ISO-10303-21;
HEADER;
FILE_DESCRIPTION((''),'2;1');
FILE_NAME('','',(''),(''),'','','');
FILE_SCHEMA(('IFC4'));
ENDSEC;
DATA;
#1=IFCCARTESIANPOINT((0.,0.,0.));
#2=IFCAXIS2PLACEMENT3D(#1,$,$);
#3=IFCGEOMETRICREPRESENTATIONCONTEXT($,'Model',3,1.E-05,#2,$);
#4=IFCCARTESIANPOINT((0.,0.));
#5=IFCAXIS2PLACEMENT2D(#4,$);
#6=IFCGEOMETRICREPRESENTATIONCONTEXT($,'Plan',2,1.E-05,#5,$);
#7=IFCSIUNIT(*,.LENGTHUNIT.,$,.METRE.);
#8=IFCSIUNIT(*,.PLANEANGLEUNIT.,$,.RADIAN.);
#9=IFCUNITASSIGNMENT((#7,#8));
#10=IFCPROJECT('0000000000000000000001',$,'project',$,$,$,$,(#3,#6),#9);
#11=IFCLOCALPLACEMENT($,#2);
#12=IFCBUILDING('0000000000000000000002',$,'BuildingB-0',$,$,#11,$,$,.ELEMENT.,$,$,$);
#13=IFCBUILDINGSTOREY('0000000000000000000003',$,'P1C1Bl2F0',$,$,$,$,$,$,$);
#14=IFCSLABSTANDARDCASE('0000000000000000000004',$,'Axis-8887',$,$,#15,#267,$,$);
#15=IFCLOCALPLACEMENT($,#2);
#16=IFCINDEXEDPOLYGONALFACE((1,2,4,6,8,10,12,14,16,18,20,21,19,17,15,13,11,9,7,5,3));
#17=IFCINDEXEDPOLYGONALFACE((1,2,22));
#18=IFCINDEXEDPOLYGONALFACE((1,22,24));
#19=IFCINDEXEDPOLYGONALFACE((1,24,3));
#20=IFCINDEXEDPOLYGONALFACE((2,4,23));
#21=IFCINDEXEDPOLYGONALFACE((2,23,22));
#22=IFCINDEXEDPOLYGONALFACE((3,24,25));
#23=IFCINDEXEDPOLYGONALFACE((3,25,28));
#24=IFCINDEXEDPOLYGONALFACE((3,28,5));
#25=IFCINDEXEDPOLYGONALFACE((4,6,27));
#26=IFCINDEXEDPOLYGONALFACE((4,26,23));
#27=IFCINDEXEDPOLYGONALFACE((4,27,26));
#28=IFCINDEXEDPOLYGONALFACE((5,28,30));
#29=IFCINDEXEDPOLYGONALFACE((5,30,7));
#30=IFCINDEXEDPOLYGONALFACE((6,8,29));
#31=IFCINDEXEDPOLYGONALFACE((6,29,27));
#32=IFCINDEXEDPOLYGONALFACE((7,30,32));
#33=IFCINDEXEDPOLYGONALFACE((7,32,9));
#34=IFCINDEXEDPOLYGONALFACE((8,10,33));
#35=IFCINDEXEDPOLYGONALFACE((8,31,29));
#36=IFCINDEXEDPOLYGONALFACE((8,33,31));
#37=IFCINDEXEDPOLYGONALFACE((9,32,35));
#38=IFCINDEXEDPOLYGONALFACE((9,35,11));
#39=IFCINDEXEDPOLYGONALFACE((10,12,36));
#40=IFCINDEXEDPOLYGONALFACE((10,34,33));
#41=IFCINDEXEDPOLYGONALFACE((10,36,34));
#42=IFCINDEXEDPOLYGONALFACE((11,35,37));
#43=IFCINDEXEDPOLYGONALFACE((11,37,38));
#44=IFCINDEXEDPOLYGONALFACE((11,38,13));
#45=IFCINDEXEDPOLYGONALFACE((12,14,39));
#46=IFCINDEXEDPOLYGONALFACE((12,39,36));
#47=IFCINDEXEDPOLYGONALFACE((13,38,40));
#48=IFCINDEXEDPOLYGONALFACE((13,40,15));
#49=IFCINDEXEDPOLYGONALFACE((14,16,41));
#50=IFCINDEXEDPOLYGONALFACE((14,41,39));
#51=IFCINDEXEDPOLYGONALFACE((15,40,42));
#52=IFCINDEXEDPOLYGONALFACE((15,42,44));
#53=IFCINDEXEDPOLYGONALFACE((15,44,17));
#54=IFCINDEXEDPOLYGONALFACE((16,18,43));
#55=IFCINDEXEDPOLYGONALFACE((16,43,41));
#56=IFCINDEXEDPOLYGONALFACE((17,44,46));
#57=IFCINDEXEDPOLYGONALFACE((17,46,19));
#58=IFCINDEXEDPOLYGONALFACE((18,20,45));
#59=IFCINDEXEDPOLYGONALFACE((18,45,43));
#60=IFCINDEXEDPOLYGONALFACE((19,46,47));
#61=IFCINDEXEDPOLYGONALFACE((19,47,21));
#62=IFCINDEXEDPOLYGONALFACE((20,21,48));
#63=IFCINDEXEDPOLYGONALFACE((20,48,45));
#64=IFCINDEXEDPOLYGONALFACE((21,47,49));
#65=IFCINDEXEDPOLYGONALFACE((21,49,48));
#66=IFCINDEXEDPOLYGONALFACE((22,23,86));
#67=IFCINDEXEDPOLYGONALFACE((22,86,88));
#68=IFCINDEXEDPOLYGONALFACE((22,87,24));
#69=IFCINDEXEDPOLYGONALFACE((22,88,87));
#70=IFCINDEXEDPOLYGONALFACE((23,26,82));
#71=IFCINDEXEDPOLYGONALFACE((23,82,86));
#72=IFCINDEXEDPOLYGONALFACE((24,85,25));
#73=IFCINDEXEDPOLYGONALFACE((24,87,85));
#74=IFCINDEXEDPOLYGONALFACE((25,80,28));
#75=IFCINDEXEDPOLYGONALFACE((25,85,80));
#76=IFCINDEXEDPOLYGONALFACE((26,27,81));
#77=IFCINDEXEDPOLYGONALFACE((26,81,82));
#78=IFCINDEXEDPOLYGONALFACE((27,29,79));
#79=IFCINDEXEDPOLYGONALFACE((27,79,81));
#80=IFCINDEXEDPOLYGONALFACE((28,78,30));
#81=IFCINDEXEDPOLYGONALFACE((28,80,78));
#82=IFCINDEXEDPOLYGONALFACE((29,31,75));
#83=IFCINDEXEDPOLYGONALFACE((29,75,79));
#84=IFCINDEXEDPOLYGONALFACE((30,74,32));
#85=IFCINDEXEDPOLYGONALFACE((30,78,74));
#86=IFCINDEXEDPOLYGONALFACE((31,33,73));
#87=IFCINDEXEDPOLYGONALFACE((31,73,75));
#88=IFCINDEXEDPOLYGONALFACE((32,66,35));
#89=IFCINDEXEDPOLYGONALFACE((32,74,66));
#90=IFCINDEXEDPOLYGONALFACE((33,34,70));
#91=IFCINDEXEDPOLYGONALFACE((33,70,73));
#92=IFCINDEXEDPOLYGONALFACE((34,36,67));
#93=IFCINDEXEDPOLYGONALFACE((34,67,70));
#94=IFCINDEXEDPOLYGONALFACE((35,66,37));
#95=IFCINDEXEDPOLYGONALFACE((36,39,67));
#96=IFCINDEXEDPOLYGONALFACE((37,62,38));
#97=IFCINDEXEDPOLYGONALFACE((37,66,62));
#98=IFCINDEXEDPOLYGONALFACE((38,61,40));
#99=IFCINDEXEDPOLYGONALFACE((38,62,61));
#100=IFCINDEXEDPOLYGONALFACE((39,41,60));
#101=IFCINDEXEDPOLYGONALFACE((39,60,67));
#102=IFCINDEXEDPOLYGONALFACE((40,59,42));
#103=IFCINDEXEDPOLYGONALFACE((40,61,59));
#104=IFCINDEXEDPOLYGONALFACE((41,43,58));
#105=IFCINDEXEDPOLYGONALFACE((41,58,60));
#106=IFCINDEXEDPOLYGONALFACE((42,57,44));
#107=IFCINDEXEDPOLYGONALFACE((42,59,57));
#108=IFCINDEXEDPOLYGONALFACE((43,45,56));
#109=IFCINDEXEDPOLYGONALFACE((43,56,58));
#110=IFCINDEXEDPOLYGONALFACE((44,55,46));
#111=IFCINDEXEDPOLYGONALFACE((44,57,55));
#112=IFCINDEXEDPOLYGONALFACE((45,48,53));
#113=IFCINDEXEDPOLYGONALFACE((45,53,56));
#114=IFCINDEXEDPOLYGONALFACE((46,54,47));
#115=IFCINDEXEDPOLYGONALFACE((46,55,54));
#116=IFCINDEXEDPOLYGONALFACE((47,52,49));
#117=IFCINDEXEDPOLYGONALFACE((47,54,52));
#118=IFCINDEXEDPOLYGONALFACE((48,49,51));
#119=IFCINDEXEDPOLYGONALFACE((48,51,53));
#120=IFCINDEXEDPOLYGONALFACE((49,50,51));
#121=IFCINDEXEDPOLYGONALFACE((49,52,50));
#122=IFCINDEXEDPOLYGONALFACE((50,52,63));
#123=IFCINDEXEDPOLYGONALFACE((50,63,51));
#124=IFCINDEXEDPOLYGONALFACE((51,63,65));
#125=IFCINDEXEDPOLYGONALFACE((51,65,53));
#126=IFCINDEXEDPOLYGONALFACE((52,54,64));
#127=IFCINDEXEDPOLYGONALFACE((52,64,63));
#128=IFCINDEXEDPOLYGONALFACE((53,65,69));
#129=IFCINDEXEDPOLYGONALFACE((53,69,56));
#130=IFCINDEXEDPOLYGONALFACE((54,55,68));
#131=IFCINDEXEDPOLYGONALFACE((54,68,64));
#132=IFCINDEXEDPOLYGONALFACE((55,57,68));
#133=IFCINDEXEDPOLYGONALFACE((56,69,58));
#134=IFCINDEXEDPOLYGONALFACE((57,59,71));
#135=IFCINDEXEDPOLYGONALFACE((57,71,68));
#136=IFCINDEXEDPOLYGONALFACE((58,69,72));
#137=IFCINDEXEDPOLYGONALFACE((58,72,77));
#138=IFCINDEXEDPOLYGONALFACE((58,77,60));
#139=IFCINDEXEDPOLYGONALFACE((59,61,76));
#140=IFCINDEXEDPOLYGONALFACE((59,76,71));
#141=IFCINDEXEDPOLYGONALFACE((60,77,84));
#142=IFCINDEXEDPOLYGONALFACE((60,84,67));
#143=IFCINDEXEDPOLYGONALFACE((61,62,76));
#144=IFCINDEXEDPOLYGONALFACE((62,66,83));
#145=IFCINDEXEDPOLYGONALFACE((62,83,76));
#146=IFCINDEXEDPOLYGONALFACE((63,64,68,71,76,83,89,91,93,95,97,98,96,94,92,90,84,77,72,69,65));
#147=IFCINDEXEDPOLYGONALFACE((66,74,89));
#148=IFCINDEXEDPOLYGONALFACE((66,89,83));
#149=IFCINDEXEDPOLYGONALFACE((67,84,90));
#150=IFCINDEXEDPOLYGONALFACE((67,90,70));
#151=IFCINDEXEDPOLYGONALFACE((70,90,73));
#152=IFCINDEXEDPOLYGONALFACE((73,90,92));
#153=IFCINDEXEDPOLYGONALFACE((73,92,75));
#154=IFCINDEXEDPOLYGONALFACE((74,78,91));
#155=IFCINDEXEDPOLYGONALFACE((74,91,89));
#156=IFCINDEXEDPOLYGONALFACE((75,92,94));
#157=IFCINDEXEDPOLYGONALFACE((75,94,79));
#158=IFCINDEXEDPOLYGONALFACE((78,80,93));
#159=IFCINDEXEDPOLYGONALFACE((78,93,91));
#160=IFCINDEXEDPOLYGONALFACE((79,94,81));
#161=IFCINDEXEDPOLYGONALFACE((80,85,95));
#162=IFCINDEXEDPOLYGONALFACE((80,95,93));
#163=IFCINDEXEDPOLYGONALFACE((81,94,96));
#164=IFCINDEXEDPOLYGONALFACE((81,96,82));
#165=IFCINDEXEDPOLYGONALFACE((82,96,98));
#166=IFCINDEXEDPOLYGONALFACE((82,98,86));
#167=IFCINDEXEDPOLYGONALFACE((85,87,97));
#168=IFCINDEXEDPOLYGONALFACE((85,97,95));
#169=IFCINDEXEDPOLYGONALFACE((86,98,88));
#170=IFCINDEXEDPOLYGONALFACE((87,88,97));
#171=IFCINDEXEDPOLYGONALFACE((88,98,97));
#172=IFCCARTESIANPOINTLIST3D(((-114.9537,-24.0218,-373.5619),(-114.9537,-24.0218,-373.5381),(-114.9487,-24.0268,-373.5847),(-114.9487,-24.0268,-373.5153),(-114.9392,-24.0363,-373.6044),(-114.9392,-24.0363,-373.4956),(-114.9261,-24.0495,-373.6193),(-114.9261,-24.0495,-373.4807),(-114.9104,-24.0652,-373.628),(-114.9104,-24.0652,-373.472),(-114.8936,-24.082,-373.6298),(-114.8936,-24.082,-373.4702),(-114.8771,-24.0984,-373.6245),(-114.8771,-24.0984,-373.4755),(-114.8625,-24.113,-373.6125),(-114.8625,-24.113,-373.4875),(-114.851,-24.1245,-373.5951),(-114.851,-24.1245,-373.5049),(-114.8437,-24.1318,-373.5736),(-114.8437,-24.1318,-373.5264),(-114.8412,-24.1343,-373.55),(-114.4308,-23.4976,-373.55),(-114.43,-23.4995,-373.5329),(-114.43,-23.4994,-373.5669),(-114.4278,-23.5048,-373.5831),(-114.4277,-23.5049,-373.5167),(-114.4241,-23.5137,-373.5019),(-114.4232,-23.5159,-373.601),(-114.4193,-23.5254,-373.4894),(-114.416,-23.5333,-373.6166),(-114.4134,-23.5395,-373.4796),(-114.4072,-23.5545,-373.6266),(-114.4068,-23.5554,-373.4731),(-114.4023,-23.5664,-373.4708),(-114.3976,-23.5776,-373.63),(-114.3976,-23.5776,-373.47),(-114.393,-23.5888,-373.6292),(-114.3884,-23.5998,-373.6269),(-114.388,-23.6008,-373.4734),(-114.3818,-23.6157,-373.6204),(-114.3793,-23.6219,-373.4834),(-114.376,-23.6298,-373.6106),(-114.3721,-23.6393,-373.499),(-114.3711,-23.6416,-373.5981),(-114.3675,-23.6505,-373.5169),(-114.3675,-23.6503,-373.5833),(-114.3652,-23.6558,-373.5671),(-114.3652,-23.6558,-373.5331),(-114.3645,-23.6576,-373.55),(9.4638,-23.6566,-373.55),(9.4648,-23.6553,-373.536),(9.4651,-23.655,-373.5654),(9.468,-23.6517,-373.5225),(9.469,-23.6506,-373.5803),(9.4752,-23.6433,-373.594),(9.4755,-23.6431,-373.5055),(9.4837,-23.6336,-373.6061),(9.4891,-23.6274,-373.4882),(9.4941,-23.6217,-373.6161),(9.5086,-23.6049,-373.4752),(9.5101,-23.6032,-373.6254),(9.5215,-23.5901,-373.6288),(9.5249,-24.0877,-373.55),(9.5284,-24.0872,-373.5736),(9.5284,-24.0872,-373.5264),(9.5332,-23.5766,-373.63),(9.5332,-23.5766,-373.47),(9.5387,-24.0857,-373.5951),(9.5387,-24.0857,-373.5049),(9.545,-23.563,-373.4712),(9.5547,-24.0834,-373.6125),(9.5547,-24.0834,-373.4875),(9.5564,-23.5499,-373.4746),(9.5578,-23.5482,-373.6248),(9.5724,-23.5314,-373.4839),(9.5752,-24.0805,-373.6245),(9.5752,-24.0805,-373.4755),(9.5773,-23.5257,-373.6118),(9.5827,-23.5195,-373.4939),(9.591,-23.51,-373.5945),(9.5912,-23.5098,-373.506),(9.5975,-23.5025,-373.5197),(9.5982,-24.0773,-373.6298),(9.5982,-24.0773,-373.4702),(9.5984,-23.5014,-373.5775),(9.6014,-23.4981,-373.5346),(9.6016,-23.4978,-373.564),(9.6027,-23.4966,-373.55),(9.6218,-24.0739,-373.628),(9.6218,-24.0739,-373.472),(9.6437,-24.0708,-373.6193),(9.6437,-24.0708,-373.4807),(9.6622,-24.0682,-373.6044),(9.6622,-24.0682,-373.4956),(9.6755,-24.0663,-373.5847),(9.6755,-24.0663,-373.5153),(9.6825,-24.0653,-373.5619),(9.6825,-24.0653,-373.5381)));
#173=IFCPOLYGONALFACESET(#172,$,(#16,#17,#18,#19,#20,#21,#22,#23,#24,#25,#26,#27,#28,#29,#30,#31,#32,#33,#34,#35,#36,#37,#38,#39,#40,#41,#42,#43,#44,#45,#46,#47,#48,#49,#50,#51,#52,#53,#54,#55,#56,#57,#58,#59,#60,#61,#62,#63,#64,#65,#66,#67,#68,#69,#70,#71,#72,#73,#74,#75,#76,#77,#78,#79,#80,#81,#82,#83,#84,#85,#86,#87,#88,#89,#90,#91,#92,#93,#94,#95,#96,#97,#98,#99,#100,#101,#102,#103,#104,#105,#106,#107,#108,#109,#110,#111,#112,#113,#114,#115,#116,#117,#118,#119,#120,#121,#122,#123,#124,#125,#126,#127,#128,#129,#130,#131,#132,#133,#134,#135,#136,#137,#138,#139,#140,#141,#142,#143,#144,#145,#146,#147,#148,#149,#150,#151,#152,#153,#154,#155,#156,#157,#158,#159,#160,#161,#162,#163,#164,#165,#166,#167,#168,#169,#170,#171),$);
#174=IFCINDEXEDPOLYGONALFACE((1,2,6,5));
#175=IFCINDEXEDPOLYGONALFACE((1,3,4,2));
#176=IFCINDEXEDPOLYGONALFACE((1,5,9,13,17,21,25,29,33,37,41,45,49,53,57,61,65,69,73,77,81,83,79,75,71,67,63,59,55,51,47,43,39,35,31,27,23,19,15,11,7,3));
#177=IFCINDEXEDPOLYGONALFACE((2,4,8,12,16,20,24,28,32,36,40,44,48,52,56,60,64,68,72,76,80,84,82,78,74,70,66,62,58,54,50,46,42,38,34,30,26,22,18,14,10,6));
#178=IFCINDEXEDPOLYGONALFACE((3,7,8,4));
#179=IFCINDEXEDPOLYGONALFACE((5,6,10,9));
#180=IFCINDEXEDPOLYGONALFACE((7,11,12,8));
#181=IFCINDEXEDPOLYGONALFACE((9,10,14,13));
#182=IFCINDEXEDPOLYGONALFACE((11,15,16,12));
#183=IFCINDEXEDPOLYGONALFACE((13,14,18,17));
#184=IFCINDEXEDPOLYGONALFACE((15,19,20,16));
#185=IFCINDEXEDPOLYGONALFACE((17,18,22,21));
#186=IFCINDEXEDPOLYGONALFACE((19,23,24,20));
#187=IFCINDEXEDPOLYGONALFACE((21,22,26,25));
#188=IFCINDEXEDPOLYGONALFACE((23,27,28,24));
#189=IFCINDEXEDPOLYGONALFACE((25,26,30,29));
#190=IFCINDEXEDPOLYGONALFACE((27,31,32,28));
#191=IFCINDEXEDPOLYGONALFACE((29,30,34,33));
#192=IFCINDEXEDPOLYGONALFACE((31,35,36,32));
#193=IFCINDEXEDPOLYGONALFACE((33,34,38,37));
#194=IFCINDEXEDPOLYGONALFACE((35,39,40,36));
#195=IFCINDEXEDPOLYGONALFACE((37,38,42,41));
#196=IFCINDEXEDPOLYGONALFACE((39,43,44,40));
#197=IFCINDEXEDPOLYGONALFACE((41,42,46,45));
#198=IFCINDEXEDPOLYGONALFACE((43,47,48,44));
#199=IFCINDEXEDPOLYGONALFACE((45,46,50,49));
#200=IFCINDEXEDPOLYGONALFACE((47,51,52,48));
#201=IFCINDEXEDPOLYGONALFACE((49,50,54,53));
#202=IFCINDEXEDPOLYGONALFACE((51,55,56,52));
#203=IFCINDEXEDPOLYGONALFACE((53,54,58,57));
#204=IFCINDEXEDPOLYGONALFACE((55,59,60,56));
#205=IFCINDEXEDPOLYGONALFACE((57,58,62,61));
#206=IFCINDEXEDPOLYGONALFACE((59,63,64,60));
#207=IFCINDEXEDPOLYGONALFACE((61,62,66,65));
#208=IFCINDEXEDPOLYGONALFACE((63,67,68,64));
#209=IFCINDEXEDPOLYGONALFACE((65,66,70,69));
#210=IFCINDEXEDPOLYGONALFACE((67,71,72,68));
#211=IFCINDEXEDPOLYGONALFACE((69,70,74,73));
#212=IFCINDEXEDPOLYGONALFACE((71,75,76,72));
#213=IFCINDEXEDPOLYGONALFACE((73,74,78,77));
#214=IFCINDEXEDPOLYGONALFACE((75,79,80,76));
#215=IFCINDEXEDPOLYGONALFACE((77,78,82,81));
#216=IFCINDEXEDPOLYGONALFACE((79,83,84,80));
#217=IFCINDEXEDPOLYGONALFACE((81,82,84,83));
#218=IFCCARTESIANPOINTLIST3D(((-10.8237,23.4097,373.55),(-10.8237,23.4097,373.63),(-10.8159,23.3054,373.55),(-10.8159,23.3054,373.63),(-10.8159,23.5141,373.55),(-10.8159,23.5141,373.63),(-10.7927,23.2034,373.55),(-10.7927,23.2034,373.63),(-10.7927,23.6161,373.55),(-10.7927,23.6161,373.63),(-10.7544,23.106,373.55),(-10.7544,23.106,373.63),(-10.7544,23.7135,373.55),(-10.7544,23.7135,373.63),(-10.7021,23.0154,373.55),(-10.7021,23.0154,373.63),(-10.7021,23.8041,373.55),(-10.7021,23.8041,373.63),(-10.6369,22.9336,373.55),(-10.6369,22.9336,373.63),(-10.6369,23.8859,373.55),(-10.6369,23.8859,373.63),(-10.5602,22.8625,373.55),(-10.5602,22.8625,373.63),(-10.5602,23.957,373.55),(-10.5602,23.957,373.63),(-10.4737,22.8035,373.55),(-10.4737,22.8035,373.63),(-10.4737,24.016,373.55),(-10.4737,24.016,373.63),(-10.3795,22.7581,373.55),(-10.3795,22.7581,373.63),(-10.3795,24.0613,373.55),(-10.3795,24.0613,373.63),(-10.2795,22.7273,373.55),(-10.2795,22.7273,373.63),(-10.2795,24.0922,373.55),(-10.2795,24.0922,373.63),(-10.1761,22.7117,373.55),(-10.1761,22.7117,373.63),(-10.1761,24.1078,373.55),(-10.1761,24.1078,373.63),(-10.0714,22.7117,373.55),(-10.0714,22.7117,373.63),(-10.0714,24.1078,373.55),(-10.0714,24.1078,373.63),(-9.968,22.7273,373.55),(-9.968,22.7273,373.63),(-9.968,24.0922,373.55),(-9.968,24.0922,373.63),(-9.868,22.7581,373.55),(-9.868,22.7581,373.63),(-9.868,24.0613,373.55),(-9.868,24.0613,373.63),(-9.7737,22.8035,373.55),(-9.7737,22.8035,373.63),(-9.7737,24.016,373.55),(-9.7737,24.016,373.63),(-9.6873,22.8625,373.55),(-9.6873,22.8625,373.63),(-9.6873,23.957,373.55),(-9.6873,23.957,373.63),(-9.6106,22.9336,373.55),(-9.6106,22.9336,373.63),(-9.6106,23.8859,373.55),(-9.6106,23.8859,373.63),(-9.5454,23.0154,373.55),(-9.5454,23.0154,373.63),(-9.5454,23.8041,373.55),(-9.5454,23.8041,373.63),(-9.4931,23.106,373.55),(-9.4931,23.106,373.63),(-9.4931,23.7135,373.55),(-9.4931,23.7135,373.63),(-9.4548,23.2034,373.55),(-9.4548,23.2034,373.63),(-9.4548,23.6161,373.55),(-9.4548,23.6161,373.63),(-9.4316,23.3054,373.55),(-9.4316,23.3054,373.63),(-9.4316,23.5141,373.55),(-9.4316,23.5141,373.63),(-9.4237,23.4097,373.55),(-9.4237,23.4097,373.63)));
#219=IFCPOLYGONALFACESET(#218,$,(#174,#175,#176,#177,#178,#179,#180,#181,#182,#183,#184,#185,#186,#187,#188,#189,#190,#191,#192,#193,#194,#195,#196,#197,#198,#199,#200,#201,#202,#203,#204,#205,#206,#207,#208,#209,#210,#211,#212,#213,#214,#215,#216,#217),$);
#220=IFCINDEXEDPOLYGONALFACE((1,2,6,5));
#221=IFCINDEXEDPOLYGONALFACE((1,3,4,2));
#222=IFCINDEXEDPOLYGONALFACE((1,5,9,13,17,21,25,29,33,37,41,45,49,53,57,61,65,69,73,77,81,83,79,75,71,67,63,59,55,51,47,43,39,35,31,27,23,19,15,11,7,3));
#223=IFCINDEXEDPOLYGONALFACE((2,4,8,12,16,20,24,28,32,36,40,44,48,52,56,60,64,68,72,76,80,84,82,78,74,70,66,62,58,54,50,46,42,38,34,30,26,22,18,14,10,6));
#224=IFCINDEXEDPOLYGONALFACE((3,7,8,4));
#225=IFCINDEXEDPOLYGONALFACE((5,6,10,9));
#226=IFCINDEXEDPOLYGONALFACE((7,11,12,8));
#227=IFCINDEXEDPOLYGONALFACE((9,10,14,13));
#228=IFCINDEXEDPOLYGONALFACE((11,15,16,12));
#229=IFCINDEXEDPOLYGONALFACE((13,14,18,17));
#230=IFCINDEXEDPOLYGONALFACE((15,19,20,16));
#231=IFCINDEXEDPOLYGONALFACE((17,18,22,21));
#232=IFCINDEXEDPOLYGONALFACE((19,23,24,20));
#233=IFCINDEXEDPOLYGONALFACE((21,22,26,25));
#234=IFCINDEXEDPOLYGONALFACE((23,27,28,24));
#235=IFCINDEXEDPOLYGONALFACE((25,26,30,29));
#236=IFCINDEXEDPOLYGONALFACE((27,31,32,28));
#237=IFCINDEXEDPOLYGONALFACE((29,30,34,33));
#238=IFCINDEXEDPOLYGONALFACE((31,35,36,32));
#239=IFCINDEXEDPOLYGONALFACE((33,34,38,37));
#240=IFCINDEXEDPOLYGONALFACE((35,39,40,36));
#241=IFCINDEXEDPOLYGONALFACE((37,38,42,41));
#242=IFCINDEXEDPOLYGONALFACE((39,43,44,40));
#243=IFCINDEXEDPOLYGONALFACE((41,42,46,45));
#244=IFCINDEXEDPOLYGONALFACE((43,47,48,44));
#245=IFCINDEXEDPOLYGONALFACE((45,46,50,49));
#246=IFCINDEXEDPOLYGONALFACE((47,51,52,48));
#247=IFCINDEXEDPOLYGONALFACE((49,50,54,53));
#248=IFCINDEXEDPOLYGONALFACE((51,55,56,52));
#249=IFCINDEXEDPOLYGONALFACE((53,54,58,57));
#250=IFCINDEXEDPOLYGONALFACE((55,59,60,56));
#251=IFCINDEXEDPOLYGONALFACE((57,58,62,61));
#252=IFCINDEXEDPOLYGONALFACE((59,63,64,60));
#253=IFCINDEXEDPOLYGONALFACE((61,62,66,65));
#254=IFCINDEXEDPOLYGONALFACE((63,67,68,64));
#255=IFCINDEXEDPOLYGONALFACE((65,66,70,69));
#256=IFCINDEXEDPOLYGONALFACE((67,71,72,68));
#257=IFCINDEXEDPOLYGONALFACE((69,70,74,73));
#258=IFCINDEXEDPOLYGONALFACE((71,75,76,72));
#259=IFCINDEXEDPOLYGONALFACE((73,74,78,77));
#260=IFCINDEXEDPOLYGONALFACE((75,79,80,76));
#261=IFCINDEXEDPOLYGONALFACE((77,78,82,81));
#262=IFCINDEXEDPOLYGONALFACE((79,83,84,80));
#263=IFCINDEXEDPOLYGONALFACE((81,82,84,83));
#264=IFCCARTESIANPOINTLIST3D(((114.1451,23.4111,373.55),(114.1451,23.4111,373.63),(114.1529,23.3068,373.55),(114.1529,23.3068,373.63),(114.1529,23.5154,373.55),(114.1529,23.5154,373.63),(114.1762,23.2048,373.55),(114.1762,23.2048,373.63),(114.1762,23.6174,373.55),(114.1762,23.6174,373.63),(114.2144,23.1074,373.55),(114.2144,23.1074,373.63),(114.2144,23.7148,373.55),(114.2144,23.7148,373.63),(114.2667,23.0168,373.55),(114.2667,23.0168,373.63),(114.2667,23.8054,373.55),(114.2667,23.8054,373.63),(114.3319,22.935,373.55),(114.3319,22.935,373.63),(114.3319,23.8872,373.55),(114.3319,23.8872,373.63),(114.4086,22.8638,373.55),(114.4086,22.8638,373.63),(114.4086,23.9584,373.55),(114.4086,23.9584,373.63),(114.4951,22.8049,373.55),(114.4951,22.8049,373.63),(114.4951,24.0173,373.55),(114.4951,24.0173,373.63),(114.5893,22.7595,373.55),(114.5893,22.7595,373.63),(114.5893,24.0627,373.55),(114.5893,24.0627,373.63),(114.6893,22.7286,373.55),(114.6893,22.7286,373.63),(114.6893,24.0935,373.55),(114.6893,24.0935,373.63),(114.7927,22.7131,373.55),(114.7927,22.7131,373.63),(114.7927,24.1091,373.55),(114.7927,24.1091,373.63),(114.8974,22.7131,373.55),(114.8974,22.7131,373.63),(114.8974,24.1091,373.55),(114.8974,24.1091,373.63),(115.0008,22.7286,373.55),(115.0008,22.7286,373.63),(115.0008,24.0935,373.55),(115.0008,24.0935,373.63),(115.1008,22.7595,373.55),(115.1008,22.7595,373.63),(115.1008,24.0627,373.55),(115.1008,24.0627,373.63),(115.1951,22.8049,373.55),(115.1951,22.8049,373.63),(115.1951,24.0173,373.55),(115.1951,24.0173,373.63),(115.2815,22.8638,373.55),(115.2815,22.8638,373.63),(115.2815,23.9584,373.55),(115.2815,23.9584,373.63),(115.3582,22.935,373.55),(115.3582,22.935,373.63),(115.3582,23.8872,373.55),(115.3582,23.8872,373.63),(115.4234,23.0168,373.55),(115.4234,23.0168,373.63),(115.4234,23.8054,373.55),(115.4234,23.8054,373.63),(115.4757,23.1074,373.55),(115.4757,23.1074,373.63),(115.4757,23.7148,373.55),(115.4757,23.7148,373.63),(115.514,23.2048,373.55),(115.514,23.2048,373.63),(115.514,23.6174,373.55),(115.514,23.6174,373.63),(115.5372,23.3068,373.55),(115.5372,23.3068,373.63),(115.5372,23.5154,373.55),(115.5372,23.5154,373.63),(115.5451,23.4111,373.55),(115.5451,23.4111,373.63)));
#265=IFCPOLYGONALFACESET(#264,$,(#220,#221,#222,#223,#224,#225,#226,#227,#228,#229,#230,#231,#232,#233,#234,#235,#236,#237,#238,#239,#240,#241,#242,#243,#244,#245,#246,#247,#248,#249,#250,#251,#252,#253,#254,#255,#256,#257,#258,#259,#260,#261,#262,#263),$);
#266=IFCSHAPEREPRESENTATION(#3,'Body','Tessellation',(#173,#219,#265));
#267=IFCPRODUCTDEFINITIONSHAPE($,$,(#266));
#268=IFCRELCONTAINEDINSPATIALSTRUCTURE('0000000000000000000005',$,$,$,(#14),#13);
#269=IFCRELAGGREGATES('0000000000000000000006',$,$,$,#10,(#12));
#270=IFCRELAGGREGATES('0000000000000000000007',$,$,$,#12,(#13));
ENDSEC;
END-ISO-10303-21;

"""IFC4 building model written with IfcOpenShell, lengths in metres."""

from ifc_helpers import new_model, entity, si_unit, frame, origin, origin_2d, place, context, project, spatial, circle, extrude, element, save


model = new_model("IFC4")

# Units and contexts
model_context = context("Model", 3, precision=1e-05, world=origin())
plan_context = context("Plan", 2, precision=1e-05, world=origin_2d())
ifc_project = project(units=[si_unit("LENGTHUNIT", "METRE"), si_unit("PLANEANGLEUNIT", "RADIAN")], contexts=[model_context, plan_context])

# Building, storey
building_placement = place(None, origin())
building = spatial("IfcBuilding", under=ifc_project, at=building_placement, Name="BuildingB-0", CompositionType="ELEMENT")
storey = spatial("IfcBuildingStorey", under=building, Name="P1C1Bl2F0")

# Slab
element("IfcSlabStandardCase", 1, inside=storey, Name="Axis-8887", context=model_context, shape_type="AdvancedSweptSolid", body=[
    entity("IfcSurfaceCurveSweptAreaSolid", entity("IfcCircleProfileDef", "AREA", None, None, 0.08), None, entity("IfcPolyline", [entity("IfcCartesianPoint", [-9.8903, 23.4097, 373.55]), entity("IfcCartesianPoint", [-9.3901, 23.9099, 373.55]), entity("IfcCartesianPoint", [114.5407, 23.911, 373.55]), entity("IfcCartesianPoint", [114.6116, 23.4111, 373.55])]), None, None, entity("IfcPlane", entity("IfcAxis2Placement3D", entity("IfcCartesianPoint", [-9.8903, 23.4097, 373.55]), entity("IfcDirection", [0.0, 0.0, 1.0]), entity("IfcDirection", [1.0, 0.0, 0.0])))),
    extrude(circle(Radius=0.7), frame((-10.1237, 23.4097, 373.55)), (0.0, 0.0, 1.0), 0.08),
    extrude(circle(Radius=0.7), frame((114.8451, 23.4111, 373.55)), (0.0, 0.0, 1.0), 0.08),
])

save(model, "model.ifc")
